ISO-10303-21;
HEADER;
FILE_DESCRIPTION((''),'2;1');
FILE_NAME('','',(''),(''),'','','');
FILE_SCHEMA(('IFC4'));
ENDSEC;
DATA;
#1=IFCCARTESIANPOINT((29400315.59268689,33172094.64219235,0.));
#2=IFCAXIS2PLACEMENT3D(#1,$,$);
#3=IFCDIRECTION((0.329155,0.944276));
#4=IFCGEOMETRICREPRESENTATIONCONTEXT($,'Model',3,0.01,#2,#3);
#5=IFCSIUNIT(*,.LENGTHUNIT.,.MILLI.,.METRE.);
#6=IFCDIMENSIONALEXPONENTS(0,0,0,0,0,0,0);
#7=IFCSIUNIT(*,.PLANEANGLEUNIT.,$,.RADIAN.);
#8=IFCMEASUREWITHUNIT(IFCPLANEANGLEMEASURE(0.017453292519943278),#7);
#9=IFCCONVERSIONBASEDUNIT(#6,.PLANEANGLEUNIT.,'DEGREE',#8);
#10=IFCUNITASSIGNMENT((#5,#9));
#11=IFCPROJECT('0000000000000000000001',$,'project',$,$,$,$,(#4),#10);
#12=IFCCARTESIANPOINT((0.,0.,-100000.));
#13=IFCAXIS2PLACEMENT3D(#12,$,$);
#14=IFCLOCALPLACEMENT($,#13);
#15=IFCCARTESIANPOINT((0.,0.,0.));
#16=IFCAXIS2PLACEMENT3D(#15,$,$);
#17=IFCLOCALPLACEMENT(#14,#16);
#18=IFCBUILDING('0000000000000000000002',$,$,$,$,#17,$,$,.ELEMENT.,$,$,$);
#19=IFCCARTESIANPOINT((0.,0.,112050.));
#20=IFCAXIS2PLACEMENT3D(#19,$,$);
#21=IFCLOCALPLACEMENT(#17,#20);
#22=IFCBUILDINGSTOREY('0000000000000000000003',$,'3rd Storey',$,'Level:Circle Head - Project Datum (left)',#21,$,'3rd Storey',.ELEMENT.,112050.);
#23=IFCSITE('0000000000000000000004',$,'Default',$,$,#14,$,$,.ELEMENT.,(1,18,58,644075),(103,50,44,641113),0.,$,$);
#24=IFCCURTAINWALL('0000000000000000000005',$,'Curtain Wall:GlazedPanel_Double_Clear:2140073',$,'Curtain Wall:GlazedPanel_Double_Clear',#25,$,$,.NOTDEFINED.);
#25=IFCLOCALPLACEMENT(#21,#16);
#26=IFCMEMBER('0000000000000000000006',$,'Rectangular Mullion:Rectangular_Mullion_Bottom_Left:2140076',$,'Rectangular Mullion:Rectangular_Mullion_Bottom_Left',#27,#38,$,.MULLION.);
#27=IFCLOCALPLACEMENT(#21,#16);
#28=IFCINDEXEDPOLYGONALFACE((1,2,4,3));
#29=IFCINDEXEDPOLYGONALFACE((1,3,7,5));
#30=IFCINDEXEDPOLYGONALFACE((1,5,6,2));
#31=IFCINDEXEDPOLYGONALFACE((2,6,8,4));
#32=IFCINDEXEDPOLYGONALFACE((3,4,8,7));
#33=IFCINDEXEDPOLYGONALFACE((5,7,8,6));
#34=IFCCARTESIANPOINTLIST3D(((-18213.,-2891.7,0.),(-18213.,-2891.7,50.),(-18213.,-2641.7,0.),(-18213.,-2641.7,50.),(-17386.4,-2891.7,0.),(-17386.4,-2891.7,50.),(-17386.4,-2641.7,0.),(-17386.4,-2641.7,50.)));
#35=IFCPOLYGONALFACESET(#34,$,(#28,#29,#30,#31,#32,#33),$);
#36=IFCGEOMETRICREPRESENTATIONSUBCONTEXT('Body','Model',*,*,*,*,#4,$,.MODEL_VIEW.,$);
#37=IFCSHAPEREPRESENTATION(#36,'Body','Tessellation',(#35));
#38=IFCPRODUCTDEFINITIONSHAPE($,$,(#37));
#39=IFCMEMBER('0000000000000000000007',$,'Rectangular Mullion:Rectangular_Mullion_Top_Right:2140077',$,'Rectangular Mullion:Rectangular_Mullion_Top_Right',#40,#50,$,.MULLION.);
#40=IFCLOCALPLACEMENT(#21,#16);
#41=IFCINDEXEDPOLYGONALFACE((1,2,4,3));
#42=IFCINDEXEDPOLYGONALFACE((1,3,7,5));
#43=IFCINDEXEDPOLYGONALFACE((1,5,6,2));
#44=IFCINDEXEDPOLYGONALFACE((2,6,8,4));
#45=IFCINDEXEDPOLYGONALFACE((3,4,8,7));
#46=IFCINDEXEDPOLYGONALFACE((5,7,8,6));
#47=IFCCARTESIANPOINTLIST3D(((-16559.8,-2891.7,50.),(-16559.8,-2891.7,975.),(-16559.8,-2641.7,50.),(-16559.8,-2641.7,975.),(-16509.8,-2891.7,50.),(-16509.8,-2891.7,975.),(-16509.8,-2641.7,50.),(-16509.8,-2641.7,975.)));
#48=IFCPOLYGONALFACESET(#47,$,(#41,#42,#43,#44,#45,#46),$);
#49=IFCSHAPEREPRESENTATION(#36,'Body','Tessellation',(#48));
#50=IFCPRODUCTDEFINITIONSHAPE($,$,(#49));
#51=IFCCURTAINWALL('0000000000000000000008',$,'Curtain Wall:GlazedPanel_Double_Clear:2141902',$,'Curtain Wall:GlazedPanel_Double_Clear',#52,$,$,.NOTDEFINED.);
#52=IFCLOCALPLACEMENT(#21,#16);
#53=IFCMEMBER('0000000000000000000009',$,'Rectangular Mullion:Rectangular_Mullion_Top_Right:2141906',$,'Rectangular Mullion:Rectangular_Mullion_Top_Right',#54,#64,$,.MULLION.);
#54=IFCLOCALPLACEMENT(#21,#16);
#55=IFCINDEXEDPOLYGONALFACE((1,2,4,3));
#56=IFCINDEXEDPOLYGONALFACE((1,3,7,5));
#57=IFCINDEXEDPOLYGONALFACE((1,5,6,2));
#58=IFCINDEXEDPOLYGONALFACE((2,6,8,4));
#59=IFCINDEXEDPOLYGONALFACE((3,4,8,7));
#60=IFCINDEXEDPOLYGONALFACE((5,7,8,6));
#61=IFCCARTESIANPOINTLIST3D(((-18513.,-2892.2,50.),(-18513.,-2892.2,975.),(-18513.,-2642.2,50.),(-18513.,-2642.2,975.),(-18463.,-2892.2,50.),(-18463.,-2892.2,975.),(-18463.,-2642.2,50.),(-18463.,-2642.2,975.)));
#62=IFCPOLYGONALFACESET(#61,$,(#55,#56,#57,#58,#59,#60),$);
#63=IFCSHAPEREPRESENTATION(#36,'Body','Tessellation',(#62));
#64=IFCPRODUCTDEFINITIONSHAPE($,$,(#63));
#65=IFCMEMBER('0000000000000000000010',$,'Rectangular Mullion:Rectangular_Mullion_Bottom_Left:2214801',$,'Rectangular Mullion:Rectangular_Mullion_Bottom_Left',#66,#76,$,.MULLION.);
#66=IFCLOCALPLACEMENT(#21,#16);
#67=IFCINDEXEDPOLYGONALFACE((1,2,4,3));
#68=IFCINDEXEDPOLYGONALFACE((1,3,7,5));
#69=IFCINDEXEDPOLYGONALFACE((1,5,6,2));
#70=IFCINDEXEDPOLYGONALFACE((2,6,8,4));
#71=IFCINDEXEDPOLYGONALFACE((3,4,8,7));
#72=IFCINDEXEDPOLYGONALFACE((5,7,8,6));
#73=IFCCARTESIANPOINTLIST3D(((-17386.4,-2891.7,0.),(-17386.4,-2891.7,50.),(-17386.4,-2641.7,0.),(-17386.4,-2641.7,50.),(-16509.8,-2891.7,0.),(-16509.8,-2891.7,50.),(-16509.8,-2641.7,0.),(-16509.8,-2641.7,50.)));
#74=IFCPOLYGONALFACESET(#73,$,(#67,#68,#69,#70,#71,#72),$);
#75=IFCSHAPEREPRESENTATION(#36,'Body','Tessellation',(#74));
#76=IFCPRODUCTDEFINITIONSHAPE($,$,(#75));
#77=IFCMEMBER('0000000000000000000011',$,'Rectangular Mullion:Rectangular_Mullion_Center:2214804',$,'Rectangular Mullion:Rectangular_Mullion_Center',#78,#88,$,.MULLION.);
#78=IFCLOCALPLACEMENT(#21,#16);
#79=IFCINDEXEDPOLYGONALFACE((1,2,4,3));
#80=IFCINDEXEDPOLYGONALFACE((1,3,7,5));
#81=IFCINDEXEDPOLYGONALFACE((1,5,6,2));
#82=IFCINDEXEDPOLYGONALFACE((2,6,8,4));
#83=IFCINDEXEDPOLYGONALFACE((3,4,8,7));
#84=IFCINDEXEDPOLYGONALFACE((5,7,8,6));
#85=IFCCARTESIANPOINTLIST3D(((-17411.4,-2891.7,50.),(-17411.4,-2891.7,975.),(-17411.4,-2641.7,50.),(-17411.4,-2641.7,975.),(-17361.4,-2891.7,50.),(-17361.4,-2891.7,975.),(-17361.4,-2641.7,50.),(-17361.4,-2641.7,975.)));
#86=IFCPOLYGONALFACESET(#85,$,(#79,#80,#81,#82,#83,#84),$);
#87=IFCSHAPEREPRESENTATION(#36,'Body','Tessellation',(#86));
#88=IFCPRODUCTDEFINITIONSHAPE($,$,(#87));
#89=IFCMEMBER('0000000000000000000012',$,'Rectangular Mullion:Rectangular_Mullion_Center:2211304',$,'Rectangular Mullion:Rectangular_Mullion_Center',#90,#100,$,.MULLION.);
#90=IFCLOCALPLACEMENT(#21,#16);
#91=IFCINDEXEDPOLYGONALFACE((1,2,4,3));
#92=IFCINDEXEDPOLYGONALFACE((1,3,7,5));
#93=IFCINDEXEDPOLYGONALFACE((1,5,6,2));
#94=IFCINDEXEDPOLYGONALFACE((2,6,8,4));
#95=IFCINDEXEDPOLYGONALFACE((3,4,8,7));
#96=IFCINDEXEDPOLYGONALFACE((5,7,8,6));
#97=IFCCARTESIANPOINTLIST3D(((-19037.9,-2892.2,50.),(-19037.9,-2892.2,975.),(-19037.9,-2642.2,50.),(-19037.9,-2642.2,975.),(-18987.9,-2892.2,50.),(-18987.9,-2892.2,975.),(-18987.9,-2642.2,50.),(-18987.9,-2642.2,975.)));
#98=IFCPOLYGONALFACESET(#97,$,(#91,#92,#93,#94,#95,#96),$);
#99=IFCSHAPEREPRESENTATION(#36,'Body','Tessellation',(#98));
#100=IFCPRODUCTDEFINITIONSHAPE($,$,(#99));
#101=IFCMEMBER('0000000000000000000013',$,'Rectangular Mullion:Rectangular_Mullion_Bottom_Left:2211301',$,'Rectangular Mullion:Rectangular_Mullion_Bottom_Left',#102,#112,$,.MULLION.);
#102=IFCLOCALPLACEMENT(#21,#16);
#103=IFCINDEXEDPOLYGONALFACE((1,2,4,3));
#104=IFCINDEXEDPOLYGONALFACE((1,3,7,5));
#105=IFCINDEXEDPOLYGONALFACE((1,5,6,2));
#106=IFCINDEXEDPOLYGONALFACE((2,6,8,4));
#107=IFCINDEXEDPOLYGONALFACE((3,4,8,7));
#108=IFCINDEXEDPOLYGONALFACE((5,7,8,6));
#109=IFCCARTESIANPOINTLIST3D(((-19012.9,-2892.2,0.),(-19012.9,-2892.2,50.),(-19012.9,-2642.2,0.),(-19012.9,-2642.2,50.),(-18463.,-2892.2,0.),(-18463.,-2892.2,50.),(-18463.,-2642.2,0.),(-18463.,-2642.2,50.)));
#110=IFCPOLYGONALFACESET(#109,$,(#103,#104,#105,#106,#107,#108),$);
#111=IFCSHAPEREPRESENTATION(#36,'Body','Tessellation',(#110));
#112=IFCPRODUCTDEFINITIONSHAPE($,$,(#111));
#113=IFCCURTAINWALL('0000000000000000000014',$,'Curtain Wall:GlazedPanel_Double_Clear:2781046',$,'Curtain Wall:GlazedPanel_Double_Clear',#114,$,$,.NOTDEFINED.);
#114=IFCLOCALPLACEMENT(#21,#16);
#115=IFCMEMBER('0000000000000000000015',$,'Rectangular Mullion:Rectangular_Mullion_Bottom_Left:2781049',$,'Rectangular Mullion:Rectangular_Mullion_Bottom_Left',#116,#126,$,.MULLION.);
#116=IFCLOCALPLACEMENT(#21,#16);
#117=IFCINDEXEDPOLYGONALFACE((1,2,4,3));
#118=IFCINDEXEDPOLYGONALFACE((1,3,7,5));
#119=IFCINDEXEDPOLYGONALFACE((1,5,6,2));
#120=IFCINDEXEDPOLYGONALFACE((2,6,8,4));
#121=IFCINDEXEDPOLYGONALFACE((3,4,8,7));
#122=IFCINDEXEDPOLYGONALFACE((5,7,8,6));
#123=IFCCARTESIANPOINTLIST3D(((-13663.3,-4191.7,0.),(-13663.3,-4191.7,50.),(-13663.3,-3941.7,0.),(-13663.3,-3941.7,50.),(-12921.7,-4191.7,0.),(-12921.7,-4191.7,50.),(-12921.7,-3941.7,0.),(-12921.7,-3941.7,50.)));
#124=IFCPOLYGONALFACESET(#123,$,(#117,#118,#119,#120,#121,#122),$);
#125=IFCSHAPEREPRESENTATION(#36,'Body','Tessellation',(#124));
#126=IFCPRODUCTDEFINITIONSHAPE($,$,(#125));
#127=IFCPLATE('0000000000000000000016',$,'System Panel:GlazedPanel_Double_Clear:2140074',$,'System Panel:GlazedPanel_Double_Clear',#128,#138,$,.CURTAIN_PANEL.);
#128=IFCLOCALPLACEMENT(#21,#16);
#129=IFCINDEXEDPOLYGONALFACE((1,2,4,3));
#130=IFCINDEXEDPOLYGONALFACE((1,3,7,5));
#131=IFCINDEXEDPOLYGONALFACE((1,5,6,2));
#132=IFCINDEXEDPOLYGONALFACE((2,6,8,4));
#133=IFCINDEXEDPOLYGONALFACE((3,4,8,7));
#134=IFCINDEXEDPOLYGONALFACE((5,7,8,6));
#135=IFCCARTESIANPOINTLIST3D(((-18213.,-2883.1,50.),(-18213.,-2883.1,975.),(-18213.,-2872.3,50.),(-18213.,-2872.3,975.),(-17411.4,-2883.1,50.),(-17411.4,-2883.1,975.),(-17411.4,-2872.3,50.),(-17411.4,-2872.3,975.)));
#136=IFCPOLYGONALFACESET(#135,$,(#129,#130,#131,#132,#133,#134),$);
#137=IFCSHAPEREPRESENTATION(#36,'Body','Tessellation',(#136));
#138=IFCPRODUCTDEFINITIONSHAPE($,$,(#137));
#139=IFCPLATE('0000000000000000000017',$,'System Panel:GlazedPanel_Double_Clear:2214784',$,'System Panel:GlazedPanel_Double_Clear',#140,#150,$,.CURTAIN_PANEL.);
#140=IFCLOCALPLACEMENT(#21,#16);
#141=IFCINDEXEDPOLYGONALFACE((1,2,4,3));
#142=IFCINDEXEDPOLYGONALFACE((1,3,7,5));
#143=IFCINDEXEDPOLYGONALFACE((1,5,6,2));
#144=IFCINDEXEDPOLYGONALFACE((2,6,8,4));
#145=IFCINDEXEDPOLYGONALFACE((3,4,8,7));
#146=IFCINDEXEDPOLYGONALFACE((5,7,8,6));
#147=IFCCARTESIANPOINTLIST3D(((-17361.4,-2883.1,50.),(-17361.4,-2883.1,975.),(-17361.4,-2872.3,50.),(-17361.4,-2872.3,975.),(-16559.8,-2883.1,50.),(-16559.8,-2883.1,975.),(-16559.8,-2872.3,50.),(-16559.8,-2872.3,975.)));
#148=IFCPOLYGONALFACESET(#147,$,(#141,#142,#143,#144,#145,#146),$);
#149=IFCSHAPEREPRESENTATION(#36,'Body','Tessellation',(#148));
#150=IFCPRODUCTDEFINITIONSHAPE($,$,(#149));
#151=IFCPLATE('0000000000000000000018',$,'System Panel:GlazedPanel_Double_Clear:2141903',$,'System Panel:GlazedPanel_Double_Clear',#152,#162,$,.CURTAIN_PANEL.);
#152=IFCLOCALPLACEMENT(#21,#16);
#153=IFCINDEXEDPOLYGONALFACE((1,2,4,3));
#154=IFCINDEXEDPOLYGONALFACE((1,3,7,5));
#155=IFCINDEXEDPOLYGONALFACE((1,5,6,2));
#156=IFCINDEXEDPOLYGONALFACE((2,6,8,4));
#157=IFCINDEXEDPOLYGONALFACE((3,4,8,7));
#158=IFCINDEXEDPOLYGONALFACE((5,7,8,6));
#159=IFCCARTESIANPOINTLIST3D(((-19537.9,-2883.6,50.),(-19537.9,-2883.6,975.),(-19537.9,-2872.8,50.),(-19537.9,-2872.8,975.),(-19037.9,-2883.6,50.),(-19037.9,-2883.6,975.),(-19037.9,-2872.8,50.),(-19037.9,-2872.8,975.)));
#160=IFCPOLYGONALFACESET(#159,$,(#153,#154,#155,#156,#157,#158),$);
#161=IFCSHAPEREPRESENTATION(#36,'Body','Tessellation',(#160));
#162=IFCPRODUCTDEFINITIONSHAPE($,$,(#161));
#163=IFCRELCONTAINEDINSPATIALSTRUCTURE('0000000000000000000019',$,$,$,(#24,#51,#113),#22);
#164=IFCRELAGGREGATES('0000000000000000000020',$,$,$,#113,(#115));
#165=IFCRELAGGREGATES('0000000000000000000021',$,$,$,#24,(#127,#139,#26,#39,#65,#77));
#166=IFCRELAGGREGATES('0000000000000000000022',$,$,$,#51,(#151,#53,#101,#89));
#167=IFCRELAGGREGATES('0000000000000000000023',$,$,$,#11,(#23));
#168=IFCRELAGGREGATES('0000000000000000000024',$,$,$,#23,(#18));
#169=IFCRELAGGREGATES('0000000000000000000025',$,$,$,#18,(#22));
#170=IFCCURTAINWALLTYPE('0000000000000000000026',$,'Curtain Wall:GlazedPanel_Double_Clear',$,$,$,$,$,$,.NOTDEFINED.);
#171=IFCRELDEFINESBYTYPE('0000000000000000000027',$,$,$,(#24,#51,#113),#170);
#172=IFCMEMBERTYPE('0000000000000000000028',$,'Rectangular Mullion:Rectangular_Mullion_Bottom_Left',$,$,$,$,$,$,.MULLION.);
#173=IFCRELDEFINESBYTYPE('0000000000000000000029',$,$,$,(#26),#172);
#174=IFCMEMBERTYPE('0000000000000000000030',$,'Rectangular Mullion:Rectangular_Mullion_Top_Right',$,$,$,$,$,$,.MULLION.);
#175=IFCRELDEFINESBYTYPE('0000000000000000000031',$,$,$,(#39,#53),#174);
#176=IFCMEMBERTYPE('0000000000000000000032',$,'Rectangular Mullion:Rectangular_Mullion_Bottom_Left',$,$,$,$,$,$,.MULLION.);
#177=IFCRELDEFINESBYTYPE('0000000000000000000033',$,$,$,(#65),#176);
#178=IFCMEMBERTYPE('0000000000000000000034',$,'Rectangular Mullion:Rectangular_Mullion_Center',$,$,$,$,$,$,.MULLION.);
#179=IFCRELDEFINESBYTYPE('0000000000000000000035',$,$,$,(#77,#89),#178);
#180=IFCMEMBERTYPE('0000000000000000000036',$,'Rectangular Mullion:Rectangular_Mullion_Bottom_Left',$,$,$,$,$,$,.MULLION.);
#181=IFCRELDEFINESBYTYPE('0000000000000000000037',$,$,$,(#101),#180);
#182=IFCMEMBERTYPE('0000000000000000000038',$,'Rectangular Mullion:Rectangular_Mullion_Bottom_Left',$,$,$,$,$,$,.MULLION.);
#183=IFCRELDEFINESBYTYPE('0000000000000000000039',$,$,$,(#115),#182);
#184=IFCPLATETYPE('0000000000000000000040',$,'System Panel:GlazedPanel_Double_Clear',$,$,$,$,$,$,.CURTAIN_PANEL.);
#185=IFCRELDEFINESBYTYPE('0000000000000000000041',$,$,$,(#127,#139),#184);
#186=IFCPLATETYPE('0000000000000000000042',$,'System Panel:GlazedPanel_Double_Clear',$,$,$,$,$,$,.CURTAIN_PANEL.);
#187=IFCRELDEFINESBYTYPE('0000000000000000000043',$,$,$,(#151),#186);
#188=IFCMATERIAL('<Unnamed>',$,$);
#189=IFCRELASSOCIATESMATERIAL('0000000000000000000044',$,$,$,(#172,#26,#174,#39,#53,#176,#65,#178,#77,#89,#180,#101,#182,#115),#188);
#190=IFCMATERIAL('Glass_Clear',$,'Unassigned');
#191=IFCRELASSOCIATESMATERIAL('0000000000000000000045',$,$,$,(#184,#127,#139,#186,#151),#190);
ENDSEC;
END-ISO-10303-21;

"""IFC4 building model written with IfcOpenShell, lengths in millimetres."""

from ifc_helpers import new_model, entity, si_unit, converted_unit, direction, frame, origin, place, context, subcontext, project, spatial, indexed_curve, outline, extrude, source, transform, mapped, material, type_object, type_shapes, element, aggregate, save


model = new_model("IFC4")

# Units and contexts
model_context = context("Model", 3, precision=0.01, world=frame((29400315.59268689, 33172094.64219235, 0.0)), true_north=direction((0.329155, 0.944276)))
body_context = subcontext(model_context, "Body", "Model", "MODEL_VIEW")
ifc_project = project(units=[si_unit("LENGTHUNIT", "METRE", prefix="MILLI"), converted_unit("PLANEANGLEUNIT", "DEGREE", entity("IfcPlaneAngleMeasure", 0.017453292519943278), si_unit("PLANEANGLEUNIT", "RADIAN"), dimensions=[0, 0, 0, 0, 0, 0, 0])], contexts=[model_context])

# Site, building, storey
site_placement = place(None, frame((0.0, 0.0, -100000.0)))
site = spatial("IfcSite", under=ifc_project, at=site_placement, Name="Default", CompositionType="ELEMENT", RefLatitude=(1, 18, 58, 644075), RefLongitude=(103, 50, 44, 641113), RefElevation=0.0)
building_placement = place(site_placement, origin())
building = spatial("IfcBuilding", under=site, at=building_placement, CompositionType="ELEMENT")
storey_placement = place(building_placement, frame((0.0, 0.0, 112050.0)))
storey = spatial("IfcBuildingStorey", under=building, at=storey_placement, Name="3rd Storey", ObjectType="Level:Circle Head - Project Datum (left)", LongName="3rd Storey", CompositionType="ELEMENT", Elevation=112050.0)

# Curtain wall, members
curtain_wall_type = type_object("IfcCurtainWallType", Name="Curtain Wall:GlazedPanel_Double_Clear", PredefinedType="NOTDEFINED")
curtain_wall_1_placement = place(storey_placement, frame((0.0, 0.0, -112050.0)))
curtain_wall_1 = element("IfcCurtainWall", 1, at=curtain_wall_1_placement, inside=storey, type_object=curtain_wall_type, Name="Curtain Wall:GlazedPanel_Double_Clear:2140073", ObjectType="Curtain Wall:GlazedPanel_Double_Clear", PredefinedType="NOTDEFINED")
ifc_material_1 = material(Name="<Unnamed>")
member_type_1 = type_object("IfcMemberType", Name="Rectangular Mullion:Rectangular_Mullion_Bottom_Left", PredefinedType="MULLION", material=ifc_material_1)
shared_shape_1 = source(origin(), body_context, "Body", "SweptSolid", [
    extrude(outline(indexed_curve([(-25.0, -125.0), (25.0, -125.0), (25.0, 125.0), (-25.0, 125.0), (-25.0, -125.0)], self_intersect=False)), frame((-25.0, 0.0, -826.6), z_axis=(0.0, 0.0, 1.0), x_axis=(-1.0, 0.0, 0.0)), (0.0, 0.0, 1.0), 826.6),
])
type_shapes(member_type_1, [shared_shape_1])
member_1_placement = place(curtain_wall_1_placement, frame((-18213.0, -2766.7, 112050.0), z_axis=(-1.0, 0.0, 0.0), x_axis=(0.0, 0.0, -1.0)))
member_1 = element("IfcMember", 2, at=member_1_placement, type_object=member_type_1, material=ifc_material_1, Name="Rectangular Mullion:Rectangular_Mullion_Bottom_Left:2140076", ObjectType="Rectangular Mullion:Rectangular_Mullion_Bottom_Left", PredefinedType="MULLION", context=body_context, shape_type="MappedRepresentation", body=[
    mapped(shared_shape_1, transform((0.0, 0.0, 0.0), scale=1.0)),
])
member_type_2 = type_object("IfcMemberType", Name="Rectangular Mullion:Rectangular_Mullion_Top_Right", PredefinedType="MULLION", material=ifc_material_1)
shared_shape_2 = source(origin(), body_context, "Body", "SweptSolid", [
    extrude(outline(indexed_curve([(-25.0, -125.0), (25.0, -125.0), (25.0, 125.0), (-25.0, 125.0), (-25.0, -125.0)], self_intersect=False)), frame((-25.0, 0.0, -925.0), z_axis=(0.0, 0.0, 1.0), x_axis=(-1.0, 0.0, 0.0)), (0.0, 0.0, 1.0), 925.0),
])
type_shapes(member_type_2, [shared_shape_2])
member_2_placement = place(curtain_wall_1_placement, frame((-16509.8, -2766.7, 112100.0), z_axis=(0.0, 0.0, -1.0), x_axis=(1.0, 0.0, 0.0)))
member_2 = element("IfcMember", 3, at=member_2_placement, type_object=member_type_2, material=ifc_material_1, Name="Rectangular Mullion:Rectangular_Mullion_Top_Right:2140077", ObjectType="Rectangular Mullion:Rectangular_Mullion_Top_Right", PredefinedType="MULLION", context=body_context, shape_type="MappedRepresentation", body=[
    mapped(shared_shape_2, transform((0.0, 0.0, 0.0), scale=1.0)),
])

# Curtain wall, member
curtain_wall_2_placement = place(storey_placement, frame((0.0, 0.0, -112050.0)))
curtain_wall_2 = element("IfcCurtainWall", 4, at=curtain_wall_2_placement, inside=storey, type_object=curtain_wall_type, Name="Curtain Wall:GlazedPanel_Double_Clear:2141902", ObjectType="Curtain Wall:GlazedPanel_Double_Clear", PredefinedType="NOTDEFINED")
member_3_placement = place(curtain_wall_2_placement, frame((-18463.0, -2767.2, 112100.0), z_axis=(0.0, 0.0, -1.0), x_axis=(1.0, 0.0, 0.0)))
member_3 = element("IfcMember", 5, at=member_3_placement, type_object=member_type_2, material=ifc_material_1, Name="Rectangular Mullion:Rectangular_Mullion_Top_Right:2141906", ObjectType="Rectangular Mullion:Rectangular_Mullion_Top_Right", PredefinedType="MULLION", context=body_context, shape_type="MappedRepresentation", body=[
    mapped(shared_shape_2, transform((0.0, 0.0, 0.0), scale=1.0)),
])

# Members
member_type_3 = type_object("IfcMemberType", Name="Rectangular Mullion:Rectangular_Mullion_Bottom_Left", PredefinedType="MULLION", material=ifc_material_1)
shared_shape_3 = source(origin(), body_context, "Body", "SweptSolid", [
    extrude(outline(indexed_curve([(-25.0, -125.0), (25.0, -125.0), (25.0, 125.0), (-25.0, 125.0), (-25.0, -125.0)], self_intersect=False)), frame((-25.0, 0.0, -876.6), z_axis=(0.0, 0.0, 1.0), x_axis=(-1.0, 0.0, 0.0)), (0.0, 0.0, 1.0), 876.6),
])
type_shapes(member_type_3, [shared_shape_3])
member_4_placement = place(curtain_wall_1_placement, frame((-17386.4, -2766.7, 112050.0), z_axis=(-1.0, 0.0, 0.0), x_axis=(0.0, 0.0, -1.0)))
member_4 = element("IfcMember", 6, at=member_4_placement, type_object=member_type_3, material=ifc_material_1, Name="Rectangular Mullion:Rectangular_Mullion_Bottom_Left:2214801", ObjectType="Rectangular Mullion:Rectangular_Mullion_Bottom_Left", PredefinedType="MULLION", context=body_context, shape_type="MappedRepresentation", body=[
    mapped(shared_shape_3, transform((0.0, 0.0, 0.0), scale=1.0)),
])
member_type_4 = type_object("IfcMemberType", Name="Rectangular Mullion:Rectangular_Mullion_Center", PredefinedType="MULLION", material=ifc_material_1)
shared_shape_4 = source(origin(), body_context, "Body", "SweptSolid", [
    extrude(outline(indexed_curve([(-25.0, -125.0), (25.0, -125.0), (25.0, 125.0), (-25.0, 125.0), (-25.0, -125.0)], self_intersect=False)), frame((0.0, 0.0, -925.0), z_axis=(0.0, 0.0, 1.0), x_axis=(-1.0, 0.0, 0.0)), (0.0, 0.0, 1.0), 925.0),
])
type_shapes(member_type_4, [shared_shape_4])
member_5_placement = place(curtain_wall_1_placement, frame((-17386.4, -2766.7, 112100.0), z_axis=(0.0, 0.0, -1.0), x_axis=(1.0, 0.0, 0.0)))
member_5 = element("IfcMember", 7, at=member_5_placement, type_object=member_type_4, material=ifc_material_1, Name="Rectangular Mullion:Rectangular_Mullion_Center:2214804", ObjectType="Rectangular Mullion:Rectangular_Mullion_Center", PredefinedType="MULLION", context=body_context, shape_type="MappedRepresentation", body=[
    mapped(shared_shape_4, transform((0.0, 0.0, 0.0), scale=1.0)),
])
member_6_placement = place(curtain_wall_2_placement, frame((-19012.9, -2767.2, 112100.0), z_axis=(0.0, 0.0, -1.0), x_axis=(1.0, 0.0, 0.0)))
member_6 = element("IfcMember", 8, at=member_6_placement, type_object=member_type_4, material=ifc_material_1, Name="Rectangular Mullion:Rectangular_Mullion_Center:2211304", ObjectType="Rectangular Mullion:Rectangular_Mullion_Center", PredefinedType="MULLION", context=body_context, shape_type="MappedRepresentation", body=[
    mapped(shared_shape_4, transform((0.0, 0.0, 0.0), scale=1.0)),
])
member_type_5 = type_object("IfcMemberType", Name="Rectangular Mullion:Rectangular_Mullion_Bottom_Left", PredefinedType="MULLION", material=ifc_material_1)
shared_shape_5 = source(origin(), body_context, "Body", "SweptSolid", [
    extrude(outline(indexed_curve([(-25.0, -125.0), (25.0, -125.0), (25.0, 125.0), (-25.0, 125.0), (-25.0, -125.0)], self_intersect=False)), frame((-25.0, 0.0, -549.9), z_axis=(0.0, 0.0, 1.0), x_axis=(-1.0, 0.0, 0.0)), (0.0, 0.0, 1.0), 549.9),
])
type_shapes(member_type_5, [shared_shape_5])
member_7_placement = place(curtain_wall_2_placement, frame((-19012.9, -2767.2, 112050.0), z_axis=(-1.0, 0.0, 0.0), x_axis=(0.0, 0.0, -1.0)))
member_7 = element("IfcMember", 9, at=member_7_placement, type_object=member_type_5, material=ifc_material_1, Name="Rectangular Mullion:Rectangular_Mullion_Bottom_Left:2211301", ObjectType="Rectangular Mullion:Rectangular_Mullion_Bottom_Left", PredefinedType="MULLION", context=body_context, shape_type="MappedRepresentation", body=[
    mapped(shared_shape_5, transform((0.0, 0.0, 0.0), scale=1.0)),
])

# Curtain wall, member
curtain_wall_3_placement = place(storey_placement, frame((0.0, 0.0, -112050.0)))
curtain_wall_3 = element("IfcCurtainWall", 10, at=curtain_wall_3_placement, inside=storey, type_object=curtain_wall_type, Name="Curtain Wall:GlazedPanel_Double_Clear:2781046", ObjectType="Curtain Wall:GlazedPanel_Double_Clear", PredefinedType="NOTDEFINED")
member_type_6 = type_object("IfcMemberType", Name="Rectangular Mullion:Rectangular_Mullion_Bottom_Left", PredefinedType="MULLION", material=ifc_material_1)
shared_shape_6 = source(origin(), body_context, "Body", "SweptSolid", [
    extrude(outline(indexed_curve([(-25.0, -125.0), (25.0, -125.0), (25.0, 125.0), (-25.0, 125.0), (-25.0, -125.0)], self_intersect=False)), frame((-25.0, 0.0, -741.7), z_axis=(0.0, 0.0, 1.0), x_axis=(-1.0, 0.0, 0.0)), (0.0, 0.0, 1.0), 741.7),
])
type_shapes(member_type_6, [shared_shape_6])
member_8_placement = place(curtain_wall_3_placement, frame((-13663.3, -4066.7, 112050.0), z_axis=(-1.0, 0.0, 0.0), x_axis=(0.0, 0.0, -1.0)))
member_8 = element("IfcMember", 11, at=member_8_placement, type_object=member_type_6, material=ifc_material_1, Name="Rectangular Mullion:Rectangular_Mullion_Bottom_Left:2781049", ObjectType="Rectangular Mullion:Rectangular_Mullion_Bottom_Left", PredefinedType="MULLION", context=body_context, shape_type="MappedRepresentation", body=[
    mapped(shared_shape_6, transform((0.0, 0.0, 0.0), scale=1.0)),
])
aggregate(curtain_wall_3, [member_8])

# Plates
ifc_material_2 = material(Name="Glass_Clear", Category="Unassigned")
plate_type_1 = type_object("IfcPlateType", Name="System Panel:GlazedPanel_Double_Clear", PredefinedType="CURTAIN_PANEL", material=ifc_material_2)
shared_shape_7 = source(origin(), body_context, "Body", "SweptSolid", [
    extrude(outline(indexed_curve([(-5.4, -400.8), (5.4, -400.8), (5.4, 400.8), (-5.4, 400.8), (-5.4, -400.8)], self_intersect=False)), frame((0.0, -111.0, 0.0), z_axis=(0.0, 0.0, 1.0), x_axis=(0.0, 1.0, 0.0)), (0.0, 0.0, 1.0), 925.0),
])
type_shapes(plate_type_1, [shared_shape_7])
plate_1_placement = place(curtain_wall_1_placement, frame((-17812.2, -2766.7, 112100.0)))
plate_1 = element("IfcPlate", 12, at=plate_1_placement, type_object=plate_type_1, material=ifc_material_2, Name="System Panel:GlazedPanel_Double_Clear:2140074", ObjectType="System Panel:GlazedPanel_Double_Clear", PredefinedType="CURTAIN_PANEL", context=body_context, shape_type="MappedRepresentation", body=[
    mapped(shared_shape_7, transform((0.0, 0.0, 0.0), scale=1.0)),
])
plate_2_placement = place(curtain_wall_1_placement, frame((-16960.6, -2766.7, 112100.0)))
plate_2 = element("IfcPlate", 13, at=plate_2_placement, type_object=plate_type_1, material=ifc_material_2, Name="System Panel:GlazedPanel_Double_Clear:2214784", ObjectType="System Panel:GlazedPanel_Double_Clear", PredefinedType="CURTAIN_PANEL", context=body_context, shape_type="MappedRepresentation", body=[
    mapped(shared_shape_7, transform((0.0, 0.0, 0.0), scale=1.0)),
])
aggregate(curtain_wall_1, [plate_1, plate_2, member_1, member_2, member_4, member_5])
plate_type_2 = type_object("IfcPlateType", Name="System Panel:GlazedPanel_Double_Clear", PredefinedType="CURTAIN_PANEL", material=ifc_material_2)
shared_shape_8 = source(origin(), body_context, "Body", "SweptSolid", [
    extrude(outline(indexed_curve([(-5.4, -250.0), (5.4, -250.0), (5.4, 250.0), (-5.4, 250.0), (-5.4, -250.0)], self_intersect=False)), frame((0.0, -111.0, 0.0), z_axis=(0.0, 0.0, 1.0), x_axis=(0.0, 1.0, 0.0)), (0.0, 0.0, 1.0), 925.0),
])
type_shapes(plate_type_2, [shared_shape_8])
plate_3_placement = place(curtain_wall_2_placement, frame((-19287.9, -2767.2, 112100.0)))
plate_3 = element("IfcPlate", 14, at=plate_3_placement, type_object=plate_type_2, material=ifc_material_2, Name="System Panel:GlazedPanel_Double_Clear:2141903", ObjectType="System Panel:GlazedPanel_Double_Clear", PredefinedType="CURTAIN_PANEL", context=body_context, shape_type="MappedRepresentation", body=[
    mapped(shared_shape_8, transform((0.0, 0.0, 0.0), scale=1.0)),
])
aggregate(curtain_wall_2, [plate_3, member_3, member_7, member_6])

save(model, "model.ifc")
